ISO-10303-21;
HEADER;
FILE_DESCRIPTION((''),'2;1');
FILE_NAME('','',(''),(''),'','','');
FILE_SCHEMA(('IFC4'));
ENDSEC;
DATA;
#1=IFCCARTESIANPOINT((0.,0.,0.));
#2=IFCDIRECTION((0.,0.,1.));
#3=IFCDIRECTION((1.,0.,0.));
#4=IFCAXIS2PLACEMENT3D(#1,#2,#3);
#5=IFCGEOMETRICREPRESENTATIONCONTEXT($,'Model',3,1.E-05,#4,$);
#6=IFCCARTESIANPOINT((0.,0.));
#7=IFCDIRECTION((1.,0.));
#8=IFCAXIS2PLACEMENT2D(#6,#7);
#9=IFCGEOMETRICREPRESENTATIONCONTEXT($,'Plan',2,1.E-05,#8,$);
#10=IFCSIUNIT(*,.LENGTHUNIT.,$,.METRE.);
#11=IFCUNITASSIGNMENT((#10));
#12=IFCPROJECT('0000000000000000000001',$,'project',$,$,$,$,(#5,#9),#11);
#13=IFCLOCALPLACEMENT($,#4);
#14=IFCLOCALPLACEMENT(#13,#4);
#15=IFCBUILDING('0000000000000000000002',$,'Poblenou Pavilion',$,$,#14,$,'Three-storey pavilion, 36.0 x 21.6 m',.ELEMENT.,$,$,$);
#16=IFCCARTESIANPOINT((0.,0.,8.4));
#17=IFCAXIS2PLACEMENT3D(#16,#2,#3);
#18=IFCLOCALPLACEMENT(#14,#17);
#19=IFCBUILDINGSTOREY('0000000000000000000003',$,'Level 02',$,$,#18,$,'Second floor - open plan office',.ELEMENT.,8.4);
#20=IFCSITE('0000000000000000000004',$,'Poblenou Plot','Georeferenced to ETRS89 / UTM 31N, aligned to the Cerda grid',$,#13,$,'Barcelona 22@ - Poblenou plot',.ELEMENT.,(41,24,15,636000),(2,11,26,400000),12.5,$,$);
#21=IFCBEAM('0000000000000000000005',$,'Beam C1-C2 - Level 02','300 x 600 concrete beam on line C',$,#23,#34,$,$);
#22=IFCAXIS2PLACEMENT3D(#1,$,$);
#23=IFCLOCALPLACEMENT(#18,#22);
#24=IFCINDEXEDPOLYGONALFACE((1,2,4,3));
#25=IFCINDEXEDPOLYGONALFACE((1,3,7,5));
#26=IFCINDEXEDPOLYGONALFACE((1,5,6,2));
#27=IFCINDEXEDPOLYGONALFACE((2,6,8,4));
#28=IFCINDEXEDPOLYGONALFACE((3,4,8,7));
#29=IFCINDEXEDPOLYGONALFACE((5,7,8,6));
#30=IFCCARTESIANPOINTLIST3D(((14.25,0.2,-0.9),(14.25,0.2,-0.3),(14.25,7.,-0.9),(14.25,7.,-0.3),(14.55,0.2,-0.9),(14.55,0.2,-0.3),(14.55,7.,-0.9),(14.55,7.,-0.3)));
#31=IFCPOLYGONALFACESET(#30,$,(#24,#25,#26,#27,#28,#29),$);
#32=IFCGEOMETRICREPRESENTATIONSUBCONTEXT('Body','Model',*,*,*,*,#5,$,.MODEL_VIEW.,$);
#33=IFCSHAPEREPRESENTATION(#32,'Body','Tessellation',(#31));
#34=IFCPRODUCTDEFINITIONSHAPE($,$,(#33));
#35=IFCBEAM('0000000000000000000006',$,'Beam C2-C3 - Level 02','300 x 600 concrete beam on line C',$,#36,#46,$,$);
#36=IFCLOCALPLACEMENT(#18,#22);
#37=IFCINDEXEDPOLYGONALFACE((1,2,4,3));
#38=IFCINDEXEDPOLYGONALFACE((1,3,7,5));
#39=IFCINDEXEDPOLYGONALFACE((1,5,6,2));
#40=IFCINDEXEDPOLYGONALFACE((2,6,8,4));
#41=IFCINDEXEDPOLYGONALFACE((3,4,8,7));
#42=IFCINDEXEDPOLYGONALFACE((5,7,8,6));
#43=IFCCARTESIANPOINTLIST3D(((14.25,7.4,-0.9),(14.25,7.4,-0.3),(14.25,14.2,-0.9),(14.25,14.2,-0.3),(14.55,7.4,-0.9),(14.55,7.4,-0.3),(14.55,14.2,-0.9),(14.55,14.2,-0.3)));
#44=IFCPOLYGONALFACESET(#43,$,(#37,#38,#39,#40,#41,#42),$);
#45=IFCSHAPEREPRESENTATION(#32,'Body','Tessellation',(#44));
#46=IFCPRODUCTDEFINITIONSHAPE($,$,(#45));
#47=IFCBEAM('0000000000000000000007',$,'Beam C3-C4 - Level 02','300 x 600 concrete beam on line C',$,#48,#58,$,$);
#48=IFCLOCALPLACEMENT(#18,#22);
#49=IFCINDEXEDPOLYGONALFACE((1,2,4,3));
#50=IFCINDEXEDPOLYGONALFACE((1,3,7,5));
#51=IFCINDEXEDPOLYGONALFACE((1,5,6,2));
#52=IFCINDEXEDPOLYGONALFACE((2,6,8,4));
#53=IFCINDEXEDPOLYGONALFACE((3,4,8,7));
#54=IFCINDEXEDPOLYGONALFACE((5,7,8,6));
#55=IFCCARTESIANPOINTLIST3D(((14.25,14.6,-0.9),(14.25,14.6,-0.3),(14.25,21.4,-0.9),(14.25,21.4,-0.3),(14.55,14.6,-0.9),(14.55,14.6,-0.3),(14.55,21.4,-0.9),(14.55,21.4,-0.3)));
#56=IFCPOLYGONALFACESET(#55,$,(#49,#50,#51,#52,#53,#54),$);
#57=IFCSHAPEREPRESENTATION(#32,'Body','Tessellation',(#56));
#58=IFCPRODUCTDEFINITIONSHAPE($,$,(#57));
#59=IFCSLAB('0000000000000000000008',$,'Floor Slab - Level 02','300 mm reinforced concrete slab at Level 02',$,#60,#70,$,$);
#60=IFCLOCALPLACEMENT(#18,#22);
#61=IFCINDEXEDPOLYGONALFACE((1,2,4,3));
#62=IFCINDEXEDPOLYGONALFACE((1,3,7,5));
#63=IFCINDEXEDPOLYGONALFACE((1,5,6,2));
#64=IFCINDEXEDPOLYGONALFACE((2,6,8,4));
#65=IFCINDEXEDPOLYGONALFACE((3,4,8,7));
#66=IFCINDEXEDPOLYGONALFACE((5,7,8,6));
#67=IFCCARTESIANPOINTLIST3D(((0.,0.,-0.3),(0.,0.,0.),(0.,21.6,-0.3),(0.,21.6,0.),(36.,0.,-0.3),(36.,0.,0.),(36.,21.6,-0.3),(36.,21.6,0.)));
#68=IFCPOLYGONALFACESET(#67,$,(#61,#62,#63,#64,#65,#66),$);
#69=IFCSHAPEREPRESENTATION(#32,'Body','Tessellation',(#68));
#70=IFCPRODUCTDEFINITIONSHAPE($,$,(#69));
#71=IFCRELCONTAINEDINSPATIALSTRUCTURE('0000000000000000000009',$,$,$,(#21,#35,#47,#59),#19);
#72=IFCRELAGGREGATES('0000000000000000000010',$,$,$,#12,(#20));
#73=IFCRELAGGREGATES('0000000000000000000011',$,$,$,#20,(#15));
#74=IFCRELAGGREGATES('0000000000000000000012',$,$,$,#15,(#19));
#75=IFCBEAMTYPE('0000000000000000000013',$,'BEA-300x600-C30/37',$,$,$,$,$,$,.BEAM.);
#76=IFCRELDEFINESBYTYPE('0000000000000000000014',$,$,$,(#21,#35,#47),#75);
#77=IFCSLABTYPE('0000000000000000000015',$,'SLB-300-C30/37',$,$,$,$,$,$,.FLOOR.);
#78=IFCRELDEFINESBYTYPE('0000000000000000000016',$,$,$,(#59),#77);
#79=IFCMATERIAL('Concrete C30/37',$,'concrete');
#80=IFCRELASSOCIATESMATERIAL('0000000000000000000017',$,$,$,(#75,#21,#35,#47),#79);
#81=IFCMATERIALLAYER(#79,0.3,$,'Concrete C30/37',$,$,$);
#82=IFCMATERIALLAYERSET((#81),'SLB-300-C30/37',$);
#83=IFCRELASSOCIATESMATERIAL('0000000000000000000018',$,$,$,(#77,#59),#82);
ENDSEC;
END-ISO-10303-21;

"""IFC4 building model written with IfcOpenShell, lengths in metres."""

from ifc_helpers import new_model, si_unit, frame, origin_with_axes, origin_2d_with_axis, place, context, subcontext, project, spatial, line, indexed_curve, rectangle, outline, extrude, material, layer, layer_set, layer_usage, material_profile, profile_set, profile_usage, type_object, element, save


model = new_model("IFC4")

# Units and contexts
model_context = context("Model", 3, precision=1e-05, world=origin_with_axes())
plan_context = context("Plan", 2, precision=1e-05, world=origin_2d_with_axis())
body_context = subcontext(model_context, "Body", "Model", "MODEL_VIEW")
ifc_project = project(units=[si_unit("LENGTHUNIT", "METRE")], contexts=[model_context, plan_context])

# Site, building, storey
site_placement = place(None, origin_with_axes())
site = spatial("IfcSite", under=ifc_project, at=site_placement, Name="Poblenou Plot", Description="Georeferenced to ETRS89 / UTM 31N, aligned to the Cerda grid", LongName="Barcelona 22@ - Poblenou plot", CompositionType="ELEMENT", RefLatitude=(41, 24, 15, 636000), RefLongitude=(2, 11, 26, 400000), RefElevation=12.5)
building_placement = place(site_placement, origin_with_axes())
building = spatial("IfcBuilding", under=site, at=building_placement, Name="Poblenou Pavilion", LongName="Three-storey pavilion, 36.0 x 21.6 m", CompositionType="ELEMENT")
storey_placement = place(building_placement, frame((0.0, 0.0, 8.4), z_axis=(0.0, 0.0, 1.0), x_axis=(1.0, 0.0, 0.0)))
storey = spatial("IfcBuildingStorey", under=building, at=storey_placement, Name="Level 02", LongName="Second floor - open plan office", CompositionType="ELEMENT", Elevation=8.4)

# Shared definitions
ifc_material = material(Name="Concrete C30/37", Category="concrete")

# Beams
ifc_material_profile_1 = material_profile(ifc_material, rectangle(XDim=0.3, YDim=0.6))
ifc_profile_set_1 = profile_set([ifc_material_profile_1], Name="BEA-300x600-C30/37")
beam_type = type_object("IfcBeamType", Name="BEA-300x600-C30/37", PredefinedType="BEAM", material=ifc_profile_set_1)
ifc_profile_usage_1 = profile_usage(ifc_profile_set_1)
beam_1_placement = place(storey_placement, frame((14.25, 0.2, -0.9), z_axis=(0.0, 1.0, 0.0), x_axis=(0.0, 0.0, 1.0)))
element("IfcBeam", 1, at=beam_1_placement, inside=storey, type_object=beam_type, material=ifc_profile_usage_1, Name="Beam C1-C2 - Level 02", Description="300 x 600 concrete beam on line C", context=body_context, shape_type="SweptSolid", body=[
    extrude(outline(indexed_curve([(0.0, 0.0), (0.6, 0.0), (0.6, 0.3), (0.0, 0.3)], segments=[line(1, 2, 3, 4, 1)])), origin_with_axes(), (0.0, 0.0, 1.0), 6.8),
])
ifc_profile_usage_2 = profile_usage(ifc_profile_set_1)
beam_2_placement = place(storey_placement, frame((14.25, 7.4, -0.9), z_axis=(0.0, 1.0, 0.0), x_axis=(0.0, 0.0, 1.0)))
element("IfcBeam", 2, at=beam_2_placement, inside=storey, type_object=beam_type, material=ifc_profile_usage_2, Name="Beam C2-C3 - Level 02", Description="300 x 600 concrete beam on line C", context=body_context, shape_type="SweptSolid", body=[
    extrude(outline(indexed_curve([(0.0, 0.0), (0.6, 0.0), (0.6, 0.3), (0.0, 0.3)], segments=[line(1, 2, 3, 4, 1)])), origin_with_axes(), (0.0, 0.0, 1.0), 6.8),
])
ifc_profile_usage_3 = profile_usage(ifc_profile_set_1)
beam_3_placement = place(storey_placement, frame((14.25, 14.6, -0.9), z_axis=(0.0, 1.0, 0.0), x_axis=(0.0, 0.0, 1.0)))
element("IfcBeam", 3, at=beam_3_placement, inside=storey, type_object=beam_type, material=ifc_profile_usage_3, Name="Beam C3-C4 - Level 02", Description="300 x 600 concrete beam on line C", context=body_context, shape_type="SweptSolid", body=[
    extrude(outline(indexed_curve([(0.0, 0.0), (0.6, 0.0), (0.6, 0.3), (0.0, 0.3)], segments=[line(1, 2, 3, 4, 1)])), origin_with_axes(), (0.0, 0.0, 1.0), 6.8),
])

# Slab
ifc_layer = layer(ifc_material, 0.3, Name="Concrete C30/37")
ifc_layer_set = layer_set([ifc_layer], Name="SLB-300-C30/37")
ifc_layer_usage = layer_usage(ifc_layer_set, "AXIS3", "POSITIVE", 0.0)
slab_type = type_object("IfcSlabType", Name="SLB-300-C30/37", PredefinedType="FLOOR", material=ifc_layer_set)
slab_placement = place(storey_placement, frame((0.0, 0.0, -0.3), z_axis=(0.0, 0.0, 1.0), x_axis=(1.0, 0.0, 0.0)))
element("IfcSlab", 4, at=slab_placement, inside=storey, type_object=slab_type, material=ifc_layer_usage, Name="Floor Slab - Level 02", Description="300 mm reinforced concrete slab at Level 02", context=body_context, shape_type="SweptSolid", body=[
    extrude(outline(indexed_curve([(0.0, 0.0), (36.0, 0.0), (36.0, 21.6), (0.0, 21.6)], segments=[line(1, 2, 3, 4, 1)])), origin_with_axes(), (0.0, 0.0, 1.0), 0.3),
])

save(model, "model.ifc")
